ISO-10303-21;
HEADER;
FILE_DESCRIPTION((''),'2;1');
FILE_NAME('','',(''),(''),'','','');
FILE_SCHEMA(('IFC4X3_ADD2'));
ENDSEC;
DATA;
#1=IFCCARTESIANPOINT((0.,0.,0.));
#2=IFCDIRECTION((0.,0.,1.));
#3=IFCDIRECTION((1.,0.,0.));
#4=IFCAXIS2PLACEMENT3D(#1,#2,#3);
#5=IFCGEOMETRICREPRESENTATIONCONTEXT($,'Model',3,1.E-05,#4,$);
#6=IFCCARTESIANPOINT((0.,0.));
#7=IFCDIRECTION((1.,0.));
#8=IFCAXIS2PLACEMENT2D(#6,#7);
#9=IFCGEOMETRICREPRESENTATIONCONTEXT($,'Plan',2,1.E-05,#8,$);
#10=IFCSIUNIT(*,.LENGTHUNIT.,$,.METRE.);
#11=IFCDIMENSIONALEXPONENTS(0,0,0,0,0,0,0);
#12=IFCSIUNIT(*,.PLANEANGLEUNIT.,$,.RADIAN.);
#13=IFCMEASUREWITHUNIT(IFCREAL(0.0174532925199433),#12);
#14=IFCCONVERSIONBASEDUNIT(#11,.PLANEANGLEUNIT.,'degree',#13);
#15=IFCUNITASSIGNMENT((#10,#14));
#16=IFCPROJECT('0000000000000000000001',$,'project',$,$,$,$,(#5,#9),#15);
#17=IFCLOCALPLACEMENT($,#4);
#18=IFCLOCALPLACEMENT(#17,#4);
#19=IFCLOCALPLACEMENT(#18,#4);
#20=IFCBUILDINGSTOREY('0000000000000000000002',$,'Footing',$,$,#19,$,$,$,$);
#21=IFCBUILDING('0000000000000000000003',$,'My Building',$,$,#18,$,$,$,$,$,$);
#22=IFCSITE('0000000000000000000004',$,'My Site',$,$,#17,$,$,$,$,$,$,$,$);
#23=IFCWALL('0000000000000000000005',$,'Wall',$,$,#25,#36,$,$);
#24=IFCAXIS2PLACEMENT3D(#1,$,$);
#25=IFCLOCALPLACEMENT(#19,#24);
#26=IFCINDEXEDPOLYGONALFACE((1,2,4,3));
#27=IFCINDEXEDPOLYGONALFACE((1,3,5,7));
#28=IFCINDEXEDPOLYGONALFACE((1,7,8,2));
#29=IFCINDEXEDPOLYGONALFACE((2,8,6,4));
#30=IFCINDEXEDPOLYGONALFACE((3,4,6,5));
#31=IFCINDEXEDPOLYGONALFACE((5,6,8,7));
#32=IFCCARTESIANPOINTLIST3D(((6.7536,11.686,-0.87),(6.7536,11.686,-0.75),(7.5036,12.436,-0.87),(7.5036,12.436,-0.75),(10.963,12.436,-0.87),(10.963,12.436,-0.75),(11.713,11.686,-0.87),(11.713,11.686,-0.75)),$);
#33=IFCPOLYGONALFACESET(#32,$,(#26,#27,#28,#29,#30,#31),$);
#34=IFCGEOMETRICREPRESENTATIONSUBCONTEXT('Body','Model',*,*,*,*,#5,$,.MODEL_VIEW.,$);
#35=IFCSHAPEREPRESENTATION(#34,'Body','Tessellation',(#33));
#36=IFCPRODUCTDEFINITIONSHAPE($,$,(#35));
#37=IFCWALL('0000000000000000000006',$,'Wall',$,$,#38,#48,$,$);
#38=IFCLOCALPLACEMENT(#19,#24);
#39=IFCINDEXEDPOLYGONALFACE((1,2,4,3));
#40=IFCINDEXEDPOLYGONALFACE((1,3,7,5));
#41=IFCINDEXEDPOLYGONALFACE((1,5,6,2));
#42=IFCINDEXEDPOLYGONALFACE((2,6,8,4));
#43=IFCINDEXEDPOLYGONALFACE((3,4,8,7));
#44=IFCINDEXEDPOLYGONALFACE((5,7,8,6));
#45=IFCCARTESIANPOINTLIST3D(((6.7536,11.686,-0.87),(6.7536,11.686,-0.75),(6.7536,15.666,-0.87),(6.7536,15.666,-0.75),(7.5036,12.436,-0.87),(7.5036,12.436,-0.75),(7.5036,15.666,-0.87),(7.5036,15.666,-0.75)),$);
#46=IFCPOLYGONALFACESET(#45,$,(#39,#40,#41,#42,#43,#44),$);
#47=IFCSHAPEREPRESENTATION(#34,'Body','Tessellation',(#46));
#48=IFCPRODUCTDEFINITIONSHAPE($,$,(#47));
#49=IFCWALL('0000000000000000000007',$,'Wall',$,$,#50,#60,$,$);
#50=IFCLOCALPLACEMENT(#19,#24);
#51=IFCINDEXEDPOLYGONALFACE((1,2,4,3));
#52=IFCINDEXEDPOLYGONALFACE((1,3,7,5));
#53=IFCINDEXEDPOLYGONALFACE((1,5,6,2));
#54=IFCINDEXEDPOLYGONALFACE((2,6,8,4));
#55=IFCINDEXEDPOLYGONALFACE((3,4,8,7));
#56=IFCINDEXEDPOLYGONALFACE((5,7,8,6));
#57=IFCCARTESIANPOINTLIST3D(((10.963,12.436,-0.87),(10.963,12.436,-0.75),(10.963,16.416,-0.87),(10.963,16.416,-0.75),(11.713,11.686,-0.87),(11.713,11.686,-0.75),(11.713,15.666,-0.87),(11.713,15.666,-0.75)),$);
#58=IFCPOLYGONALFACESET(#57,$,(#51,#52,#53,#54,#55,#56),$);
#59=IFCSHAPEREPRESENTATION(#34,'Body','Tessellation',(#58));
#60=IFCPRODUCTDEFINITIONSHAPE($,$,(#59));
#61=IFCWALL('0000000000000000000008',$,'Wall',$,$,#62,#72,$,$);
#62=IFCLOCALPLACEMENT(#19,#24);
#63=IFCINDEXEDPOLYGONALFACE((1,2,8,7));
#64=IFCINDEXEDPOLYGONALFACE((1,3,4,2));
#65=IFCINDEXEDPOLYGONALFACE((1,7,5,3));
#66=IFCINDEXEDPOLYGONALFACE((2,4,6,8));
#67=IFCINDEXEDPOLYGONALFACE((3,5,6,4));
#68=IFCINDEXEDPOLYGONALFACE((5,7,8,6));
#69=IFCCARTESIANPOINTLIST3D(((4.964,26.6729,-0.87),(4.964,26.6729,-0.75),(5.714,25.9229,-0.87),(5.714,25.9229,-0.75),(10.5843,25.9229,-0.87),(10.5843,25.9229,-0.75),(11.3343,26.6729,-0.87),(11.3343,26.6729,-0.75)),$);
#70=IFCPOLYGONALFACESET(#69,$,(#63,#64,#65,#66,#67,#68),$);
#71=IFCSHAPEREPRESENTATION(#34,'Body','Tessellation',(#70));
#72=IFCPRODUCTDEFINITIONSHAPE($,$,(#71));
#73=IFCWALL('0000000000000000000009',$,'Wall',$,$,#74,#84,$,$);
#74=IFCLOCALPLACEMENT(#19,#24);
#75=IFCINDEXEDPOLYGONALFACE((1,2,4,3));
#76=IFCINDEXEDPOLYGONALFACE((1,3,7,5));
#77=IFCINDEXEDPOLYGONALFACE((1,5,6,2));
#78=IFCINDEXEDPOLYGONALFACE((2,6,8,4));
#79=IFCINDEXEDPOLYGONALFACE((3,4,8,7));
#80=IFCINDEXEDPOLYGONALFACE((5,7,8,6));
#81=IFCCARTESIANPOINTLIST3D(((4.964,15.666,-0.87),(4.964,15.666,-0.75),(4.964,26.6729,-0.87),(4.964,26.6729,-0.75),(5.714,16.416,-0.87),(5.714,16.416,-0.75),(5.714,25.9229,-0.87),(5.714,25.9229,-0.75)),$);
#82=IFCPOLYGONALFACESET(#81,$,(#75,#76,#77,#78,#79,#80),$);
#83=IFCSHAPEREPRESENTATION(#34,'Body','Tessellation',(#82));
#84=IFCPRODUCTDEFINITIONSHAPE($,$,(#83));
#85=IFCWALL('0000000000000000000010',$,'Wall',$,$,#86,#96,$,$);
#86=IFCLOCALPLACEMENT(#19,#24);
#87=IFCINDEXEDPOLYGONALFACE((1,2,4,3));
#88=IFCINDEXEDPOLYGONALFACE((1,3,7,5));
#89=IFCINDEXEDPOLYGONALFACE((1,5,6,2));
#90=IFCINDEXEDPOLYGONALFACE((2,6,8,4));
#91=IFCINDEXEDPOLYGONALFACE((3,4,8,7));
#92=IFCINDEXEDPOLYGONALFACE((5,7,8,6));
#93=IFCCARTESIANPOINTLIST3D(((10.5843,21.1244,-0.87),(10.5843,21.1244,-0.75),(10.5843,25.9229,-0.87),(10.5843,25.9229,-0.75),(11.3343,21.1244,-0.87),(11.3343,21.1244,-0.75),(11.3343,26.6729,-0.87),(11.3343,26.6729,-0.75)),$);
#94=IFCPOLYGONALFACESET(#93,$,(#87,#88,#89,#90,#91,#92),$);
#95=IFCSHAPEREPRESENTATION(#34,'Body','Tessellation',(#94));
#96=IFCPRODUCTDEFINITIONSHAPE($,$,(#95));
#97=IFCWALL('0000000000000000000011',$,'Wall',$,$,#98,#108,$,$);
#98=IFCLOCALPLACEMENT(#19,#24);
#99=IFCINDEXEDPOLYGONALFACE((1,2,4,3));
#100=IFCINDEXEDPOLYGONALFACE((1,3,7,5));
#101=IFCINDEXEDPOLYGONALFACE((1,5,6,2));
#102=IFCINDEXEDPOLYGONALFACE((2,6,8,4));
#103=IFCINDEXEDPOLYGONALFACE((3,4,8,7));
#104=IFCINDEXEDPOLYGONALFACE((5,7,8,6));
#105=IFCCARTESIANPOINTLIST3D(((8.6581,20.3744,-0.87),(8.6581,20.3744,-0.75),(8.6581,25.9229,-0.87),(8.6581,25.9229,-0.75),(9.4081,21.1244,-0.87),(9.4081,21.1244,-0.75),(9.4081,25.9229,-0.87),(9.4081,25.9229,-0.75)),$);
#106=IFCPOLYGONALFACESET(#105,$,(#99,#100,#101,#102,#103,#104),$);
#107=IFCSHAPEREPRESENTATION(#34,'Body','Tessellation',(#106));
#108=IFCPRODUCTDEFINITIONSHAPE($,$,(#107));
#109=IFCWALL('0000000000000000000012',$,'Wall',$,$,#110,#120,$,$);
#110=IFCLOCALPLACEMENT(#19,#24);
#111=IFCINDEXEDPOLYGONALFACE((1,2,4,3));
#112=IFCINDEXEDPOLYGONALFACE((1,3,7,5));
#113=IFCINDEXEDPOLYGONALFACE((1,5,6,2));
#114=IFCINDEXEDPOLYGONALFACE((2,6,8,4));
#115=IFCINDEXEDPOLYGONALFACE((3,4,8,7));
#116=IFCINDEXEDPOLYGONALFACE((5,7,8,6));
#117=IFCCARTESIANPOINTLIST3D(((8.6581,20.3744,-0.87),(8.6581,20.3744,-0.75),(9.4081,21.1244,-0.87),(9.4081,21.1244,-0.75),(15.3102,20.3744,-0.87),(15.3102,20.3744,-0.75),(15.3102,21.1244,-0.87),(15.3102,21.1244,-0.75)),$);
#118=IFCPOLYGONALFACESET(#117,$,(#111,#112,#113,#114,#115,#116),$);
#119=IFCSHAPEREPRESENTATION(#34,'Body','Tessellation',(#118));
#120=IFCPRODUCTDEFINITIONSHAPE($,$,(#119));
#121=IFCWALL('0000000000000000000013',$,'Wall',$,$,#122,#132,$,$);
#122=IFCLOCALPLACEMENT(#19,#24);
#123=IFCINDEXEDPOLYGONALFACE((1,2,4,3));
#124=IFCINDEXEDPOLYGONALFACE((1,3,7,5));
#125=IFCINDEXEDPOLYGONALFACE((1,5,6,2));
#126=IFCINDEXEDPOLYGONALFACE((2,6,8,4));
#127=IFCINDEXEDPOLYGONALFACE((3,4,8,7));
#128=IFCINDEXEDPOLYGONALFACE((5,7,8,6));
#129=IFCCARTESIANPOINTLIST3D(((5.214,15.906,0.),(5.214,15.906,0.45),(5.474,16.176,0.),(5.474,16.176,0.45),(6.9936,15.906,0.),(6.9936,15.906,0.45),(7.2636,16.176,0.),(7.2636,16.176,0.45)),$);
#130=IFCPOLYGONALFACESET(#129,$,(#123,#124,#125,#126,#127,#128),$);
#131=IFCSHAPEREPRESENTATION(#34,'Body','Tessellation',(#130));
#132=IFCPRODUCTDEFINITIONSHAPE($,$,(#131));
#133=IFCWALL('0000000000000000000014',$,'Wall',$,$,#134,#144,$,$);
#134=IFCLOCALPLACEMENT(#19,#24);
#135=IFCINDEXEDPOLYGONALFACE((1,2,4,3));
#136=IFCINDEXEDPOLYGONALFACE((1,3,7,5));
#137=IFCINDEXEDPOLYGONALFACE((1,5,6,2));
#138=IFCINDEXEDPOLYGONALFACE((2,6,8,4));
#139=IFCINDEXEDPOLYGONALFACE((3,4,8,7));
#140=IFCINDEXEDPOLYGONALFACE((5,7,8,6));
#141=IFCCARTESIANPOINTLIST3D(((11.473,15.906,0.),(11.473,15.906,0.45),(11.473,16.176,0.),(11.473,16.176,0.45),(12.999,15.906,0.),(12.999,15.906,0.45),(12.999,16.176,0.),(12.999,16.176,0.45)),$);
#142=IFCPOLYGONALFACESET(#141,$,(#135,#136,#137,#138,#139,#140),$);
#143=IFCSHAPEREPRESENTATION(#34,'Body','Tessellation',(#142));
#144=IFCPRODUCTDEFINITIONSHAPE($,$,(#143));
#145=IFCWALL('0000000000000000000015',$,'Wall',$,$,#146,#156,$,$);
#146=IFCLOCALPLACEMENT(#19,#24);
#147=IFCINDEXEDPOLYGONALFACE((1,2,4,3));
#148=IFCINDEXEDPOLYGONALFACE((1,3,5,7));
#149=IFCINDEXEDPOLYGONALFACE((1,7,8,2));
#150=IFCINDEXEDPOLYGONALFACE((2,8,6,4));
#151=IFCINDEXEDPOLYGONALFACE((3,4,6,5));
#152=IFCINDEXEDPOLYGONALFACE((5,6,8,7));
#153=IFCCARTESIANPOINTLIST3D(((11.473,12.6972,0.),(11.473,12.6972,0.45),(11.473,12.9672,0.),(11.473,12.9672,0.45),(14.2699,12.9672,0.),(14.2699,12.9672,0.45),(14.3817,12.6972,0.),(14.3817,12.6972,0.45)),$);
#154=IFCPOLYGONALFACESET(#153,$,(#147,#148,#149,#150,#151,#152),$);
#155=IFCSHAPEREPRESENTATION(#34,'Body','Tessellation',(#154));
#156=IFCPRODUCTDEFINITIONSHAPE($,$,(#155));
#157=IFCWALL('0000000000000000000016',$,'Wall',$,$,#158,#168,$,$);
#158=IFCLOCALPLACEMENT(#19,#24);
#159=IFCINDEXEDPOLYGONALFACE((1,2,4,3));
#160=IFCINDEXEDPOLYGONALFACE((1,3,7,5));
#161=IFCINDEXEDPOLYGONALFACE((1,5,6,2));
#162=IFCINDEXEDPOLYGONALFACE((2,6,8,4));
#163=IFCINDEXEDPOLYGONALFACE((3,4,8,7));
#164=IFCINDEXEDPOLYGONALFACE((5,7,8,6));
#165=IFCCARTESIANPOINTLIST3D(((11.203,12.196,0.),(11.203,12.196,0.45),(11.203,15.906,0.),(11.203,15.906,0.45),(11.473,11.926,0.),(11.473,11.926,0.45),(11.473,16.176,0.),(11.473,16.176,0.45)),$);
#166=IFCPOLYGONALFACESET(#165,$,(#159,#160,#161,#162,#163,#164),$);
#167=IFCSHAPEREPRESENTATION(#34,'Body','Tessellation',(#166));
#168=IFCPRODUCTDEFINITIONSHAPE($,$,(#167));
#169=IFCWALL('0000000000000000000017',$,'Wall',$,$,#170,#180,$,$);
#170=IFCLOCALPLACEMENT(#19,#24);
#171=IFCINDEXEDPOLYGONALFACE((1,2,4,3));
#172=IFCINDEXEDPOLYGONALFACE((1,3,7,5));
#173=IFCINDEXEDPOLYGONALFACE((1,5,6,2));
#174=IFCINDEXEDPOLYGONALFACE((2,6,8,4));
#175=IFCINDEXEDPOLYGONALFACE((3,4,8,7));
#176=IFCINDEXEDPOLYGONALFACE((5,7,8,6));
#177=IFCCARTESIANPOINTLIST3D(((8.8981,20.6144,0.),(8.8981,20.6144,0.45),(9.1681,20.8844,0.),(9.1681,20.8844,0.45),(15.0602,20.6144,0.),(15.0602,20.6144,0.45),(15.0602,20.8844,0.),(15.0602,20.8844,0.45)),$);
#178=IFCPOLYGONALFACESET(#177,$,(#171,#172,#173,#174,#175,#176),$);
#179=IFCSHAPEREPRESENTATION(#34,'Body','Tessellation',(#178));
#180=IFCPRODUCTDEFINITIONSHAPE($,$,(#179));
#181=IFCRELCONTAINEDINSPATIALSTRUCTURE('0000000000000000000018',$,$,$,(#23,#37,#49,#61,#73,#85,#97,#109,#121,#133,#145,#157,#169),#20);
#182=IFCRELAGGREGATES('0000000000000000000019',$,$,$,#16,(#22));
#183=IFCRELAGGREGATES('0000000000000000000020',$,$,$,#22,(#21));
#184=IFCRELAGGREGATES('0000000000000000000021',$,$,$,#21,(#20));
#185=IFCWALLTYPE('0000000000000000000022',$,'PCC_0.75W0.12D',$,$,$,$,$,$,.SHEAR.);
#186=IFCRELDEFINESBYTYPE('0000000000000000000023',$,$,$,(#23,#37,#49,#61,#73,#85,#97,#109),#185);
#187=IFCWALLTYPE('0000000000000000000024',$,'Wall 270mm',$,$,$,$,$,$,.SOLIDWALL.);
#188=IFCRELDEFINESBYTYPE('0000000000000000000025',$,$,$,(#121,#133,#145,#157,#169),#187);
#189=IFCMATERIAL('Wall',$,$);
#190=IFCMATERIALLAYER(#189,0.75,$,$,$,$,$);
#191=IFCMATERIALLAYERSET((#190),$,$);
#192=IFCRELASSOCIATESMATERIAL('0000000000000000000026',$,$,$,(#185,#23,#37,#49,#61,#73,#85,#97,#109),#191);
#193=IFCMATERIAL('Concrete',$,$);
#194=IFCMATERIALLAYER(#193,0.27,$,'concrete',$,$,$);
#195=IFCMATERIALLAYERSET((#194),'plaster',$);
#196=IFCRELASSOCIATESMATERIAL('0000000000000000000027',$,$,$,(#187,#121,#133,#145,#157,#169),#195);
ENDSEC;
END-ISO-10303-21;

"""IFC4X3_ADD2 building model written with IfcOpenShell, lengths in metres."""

from ifc_helpers import new_model, entity, si_unit, converted_unit, frame, origin_with_axes, origin_2d_with_axis, place, context, subcontext, project, spatial, line, indexed_curve, outline, extrude, material, layer, layer_set, layer_usage, type_object, element, save


model = new_model("IFC4X3_ADD2")

# Units and contexts
model_context = context("Model", 3, precision=1e-05, world=origin_with_axes())
plan_context = context("Plan", 2, precision=1e-05, world=origin_2d_with_axis())
body_context = subcontext(model_context, "Body", "Model", "MODEL_VIEW")
ifc_project = project(units=[si_unit("LENGTHUNIT", "METRE"), converted_unit("PLANEANGLEUNIT", "degree", entity("IfcReal", 0.0174532925199433), si_unit("PLANEANGLEUNIT", "RADIAN"), dimensions=[0, 0, 0, 0, 0, 0, 0])], contexts=[model_context, plan_context])

# Site, building, storey
site_placement = place(None, origin_with_axes())
site = spatial("IfcSite", under=ifc_project, at=site_placement, Name="My Site")
building_placement = place(site_placement, origin_with_axes())
building = spatial("IfcBuilding", under=site, at=building_placement, Name="My Building")
storey_placement = place(building_placement, origin_with_axes())
storey = spatial("IfcBuildingStorey", under=building, at=storey_placement, Name="Footing")

# Walls
ifc_material_1 = material(Name="Wall")
ifc_layer_1 = layer(ifc_material_1, 0.75)
ifc_layer_set_1 = layer_set([ifc_layer_1])
ifc_layer_usage_1 = layer_usage(ifc_layer_set_1, "AXIS2", "POSITIVE", 0.0)
wall_type_1 = type_object("IfcWallType", Name="PCC_0.75W0.12D", PredefinedType="SHEAR", material=ifc_layer_set_1)
wall_1_placement = place(storey_placement, frame((11.713, 12.436, -0.87), z_axis=(0.0, 0.0, 1.0), x_axis=(-1.0, 0.0, 0.0)))
element("IfcWall", 1, at=wall_1_placement, inside=storey, type_object=wall_type_1, material=ifc_layer_usage_1, Name="Wall", context=body_context, shape_type="SweptSolid", body=[
    extrude(outline(indexed_curve([(0.75, 0.0), (0.0, 0.75), (4.9594, 0.75), (4.2094, 0.0)], segments=[line(1, 2, 3, 4, 1)])), origin_with_axes(), (0.0, 0.0, 1.0), 0.12),
])
ifc_layer_usage_2 = layer_usage(ifc_layer_set_1, "AXIS2", "POSITIVE", 0.0)
wall_2_placement = place(storey_placement, frame((7.5036, 12.436, -0.87), z_axis=(0.0, 0.0, 1.0), x_axis=(0.0, 1.0, 0.0)))
element("IfcWall", 2, at=wall_2_placement, inside=storey, type_object=wall_type_1, material=ifc_layer_usage_2, Name="Wall", context=body_context, shape_type="SweptSolid", body=[
    extrude(outline(indexed_curve([(0.0, 0.0), (-0.75, 0.75), (3.23, 0.75), (3.23, 0.0)], segments=[line(1, 2, 3, 4, 1)])), origin_with_axes(), (0.0, 0.0, 1.0), 0.12),
])
ifc_layer_usage_3 = layer_usage(ifc_layer_set_1, "AXIS2", "POSITIVE", 0.0)
wall_3_placement = place(storey_placement, frame((11.713, 12.436, -0.87), z_axis=(0.0, 0.0, 1.0), x_axis=(0.0, 1.0, 0.0)))
element("IfcWall", 3, at=wall_3_placement, inside=storey, type_object=wall_type_1, material=ifc_layer_usage_3, Name="Wall", context=body_context, shape_type="SweptSolid", body=[
    extrude(outline(indexed_curve([(-0.75, 0.0), (0.0, 0.75), (3.98, 0.75), (3.23, 0.0)], segments=[line(1, 2, 3, 4, 1)])), origin_with_axes(), (0.0, 0.0, 1.0), 0.12),
])
ifc_layer_usage_4 = layer_usage(ifc_layer_set_1, "AXIS2", "POSITIVE", 0.0)
wall_4_placement = place(storey_placement, frame((11.3343, 26.6729, -0.87), z_axis=(0.0, 0.0, 1.0), x_axis=(-1.0, 0.0, 0.0)))
element("IfcWall", 4, at=wall_4_placement, inside=storey, type_object=wall_type_1, material=ifc_layer_usage_4, Name="Wall", context=body_context, shape_type="SweptSolid", body=[
    extrude(outline(indexed_curve([(0.0, 0.0), (0.75, 0.75), (5.6203, 0.75), (6.3703, 0.0)], segments=[line(1, 2, 3, 4, 1)])), origin_with_axes(), (0.0, 0.0, 1.0), 0.12),
])
ifc_layer_usage_5 = layer_usage(ifc_layer_set_1, "AXIS2", "POSITIVE", 0.0)
wall_5_placement = place(storey_placement, frame((5.714, 16.416, -0.87), z_axis=(0.0, 0.0, 1.0), x_axis=(0.0, 1.0, 0.0)))
element("IfcWall", 5, at=wall_5_placement, inside=storey, type_object=wall_type_1, material=ifc_layer_usage_5, Name="Wall", context=body_context, shape_type="SweptSolid", body=[
    extrude(outline(indexed_curve([(0.0, 0.0), (-0.75, 0.75), (10.2569, 0.75), (9.5069, 0.0)], segments=[line(1, 2, 3, 4, 1)])), origin_with_axes(), (0.0, 0.0, 1.0), 0.12),
])
ifc_layer_usage_6 = layer_usage(ifc_layer_set_1, "AXIS2", "POSITIVE", 0.0)
wall_6_placement = place(storey_placement, frame((11.3343, 20.3744, -0.87), z_axis=(0.0, 0.0, 1.0), x_axis=(0.0, 1.0, 0.0)))
element("IfcWall", 6, at=wall_6_placement, inside=storey, type_object=wall_type_1, material=ifc_layer_usage_6, Name="Wall", context=body_context, shape_type="SweptSolid", body=[
    extrude(outline(indexed_curve([(0.75, 0.0), (0.75, 0.75), (5.5485, 0.75), (6.2985, 0.0)], segments=[line(1, 2, 3, 4, 1)])), origin_with_axes(), (0.0, 0.0, 1.0), 0.12),
])
ifc_layer_usage_7 = layer_usage(ifc_layer_set_1, "AXIS2", "POSITIVE", 0.0)
wall_7_placement = place(storey_placement, frame((9.4081, 20.3744, -0.87), z_axis=(0.0, 0.0, 1.0), x_axis=(0.0, 1.0, 0.0)))
element("IfcWall", 7, at=wall_7_placement, inside=storey, type_object=wall_type_1, material=ifc_layer_usage_7, Name="Wall", context=body_context, shape_type="SweptSolid", body=[
    extrude(outline(indexed_curve([(0.75, 0.0), (0.0, 0.75), (5.5485, 0.75), (5.5485, 0.0)], segments=[line(1, 2, 3, 4, 1)])), origin_with_axes(), (0.0, 0.0, 1.0), 0.12),
])
ifc_layer_usage_8 = layer_usage(ifc_layer_set_1, "AXIS2", "POSITIVE", 0.0)
wall_8_placement = place(storey_placement, frame((9.4081, 20.3744, -0.87), z_axis=(0.0, 0.0, 1.0), x_axis=(1.0, -0.000001, 0.0)))
element("IfcWall", 8, at=wall_8_placement, inside=storey, type_object=wall_type_1, material=ifc_layer_usage_8, Name="Wall", context=body_context, shape_type="SweptSolid", body=[
    extrude(outline(indexed_curve([(-0.75, 0.0), (0.0, 0.75), (5.9021, 0.75), (5.9021, 0.0)], segments=[line(1, 2, 3, 4, 1)])), origin_with_axes(), (0.0, 0.0, 1.0), 0.12),
])
ifc_material_2 = material(Name="Concrete")
ifc_layer_2 = layer(ifc_material_2, 0.27, Name="concrete")
ifc_layer_set_2 = layer_set([ifc_layer_2], Name="plaster")
ifc_layer_usage_9 = layer_usage(ifc_layer_set_2, "AXIS2", "POSITIVE", 0.0)
wall_type_2 = type_object("IfcWallType", Name="Wall 270mm", PredefinedType="SOLIDWALL", material=ifc_layer_set_2)
wall_9_placement = place(storey_placement, frame((5.474, 15.906, 0.0), z_axis=(0.0, 0.0, 1.0), x_axis=(1.0, 0.0, 0.0)))
element("IfcWall", 9, at=wall_9_placement, inside=storey, type_object=wall_type_2, material=ifc_layer_usage_9, Name="Wall", context=body_context, shape_type="SweptSolid", body=[
    extrude(outline(indexed_curve([(-0.26, 0.0), (0.0, 0.27), (1.7896, 0.27), (1.5196, 0.0)], segments=[line(1, 2, 3, 4, 1)])), origin_with_axes(), (0.0, 0.0, 1.0), 0.45),
])
ifc_layer_usage_10 = layer_usage(ifc_layer_set_2, "AXIS2", "POSITIVE", 0.0)
wall_10_placement = place(storey_placement, frame((11.473, 15.906, 0.0), z_axis=(0.0, 0.0, 1.0), x_axis=(1.0, 0.0, 0.0)))
element("IfcWall", 10, at=wall_10_placement, inside=storey, type_object=wall_type_2, material=ifc_layer_usage_10, Name="Wall", context=body_context, shape_type="SweptSolid", body=[
    extrude(outline(indexed_curve([(0.0, 0.0), (0.0, 0.27), (1.526, 0.27), (1.526, 0.0)], segments=[line(1, 2, 3, 4, 1)])), origin_with_axes(), (0.0, 0.0, 1.0), 0.45),
])
ifc_layer_usage_11 = layer_usage(ifc_layer_set_2, "AXIS2", "POSITIVE", 0.0)
wall_11_placement = place(storey_placement, frame((11.473, 12.6972, 0.0), z_axis=(0.0, 0.0, 1.0), x_axis=(1.0, 0.0, 0.0)))
element("IfcWall", 11, at=wall_11_placement, inside=storey, type_object=wall_type_2, material=ifc_layer_usage_11, Name="Wall", context=body_context, shape_type="SweptSolid", body=[
    extrude(outline(indexed_curve([(0.0, 0.0), (0.0, 0.27), (2.7969, 0.27), (2.9087, 0.0)], segments=[line(1, 2, 3, 4, 1)])), origin_with_axes(), (0.0, 0.0, 1.0), 0.45),
])
ifc_layer_usage_12 = layer_usage(ifc_layer_set_2, "AXIS2", "POSITIVE", 0.0)
wall_12_placement = place(storey_placement, frame((11.473, 11.926, 0.0), z_axis=(0.0, 0.0, 1.0), x_axis=(0.0, 1.0, 0.0)))
element("IfcWall", 12, at=wall_12_placement, inside=storey, type_object=wall_type_2, material=ifc_layer_usage_12, Name="Wall", context=body_context, shape_type="SweptSolid", body=[
    extrude(outline(indexed_curve([(0.0, 0.0), (0.27, 0.27), (3.98, 0.27), (4.25, 0.0)], segments=[line(1, 2, 3, 4, 1)])), origin_with_axes(), (0.0, 0.0, 1.0), 0.45),
])
ifc_layer_usage_13 = layer_usage(ifc_layer_set_2, "AXIS2", "POSITIVE", 0.0)
wall_13_placement = place(storey_placement, frame((9.1681, 20.6144, 0.0), z_axis=(0.0, 0.0, 1.0), x_axis=(1.0, 0.0, 0.0)))
element("IfcWall", 13, at=wall_13_placement, inside=storey, type_object=wall_type_2, material=ifc_layer_usage_13, Name="Wall", context=body_context, shape_type="SweptSolid", body=[
    extrude(outline(indexed_curve([(-0.27, 0.0), (0.0, 0.27), (5.8921, 0.27), (5.8921, 0.0)], segments=[line(1, 2, 3, 4, 1)])), origin_with_axes(), (0.0, 0.0, 1.0), 0.45),
])

save(model, "model.ifc")
